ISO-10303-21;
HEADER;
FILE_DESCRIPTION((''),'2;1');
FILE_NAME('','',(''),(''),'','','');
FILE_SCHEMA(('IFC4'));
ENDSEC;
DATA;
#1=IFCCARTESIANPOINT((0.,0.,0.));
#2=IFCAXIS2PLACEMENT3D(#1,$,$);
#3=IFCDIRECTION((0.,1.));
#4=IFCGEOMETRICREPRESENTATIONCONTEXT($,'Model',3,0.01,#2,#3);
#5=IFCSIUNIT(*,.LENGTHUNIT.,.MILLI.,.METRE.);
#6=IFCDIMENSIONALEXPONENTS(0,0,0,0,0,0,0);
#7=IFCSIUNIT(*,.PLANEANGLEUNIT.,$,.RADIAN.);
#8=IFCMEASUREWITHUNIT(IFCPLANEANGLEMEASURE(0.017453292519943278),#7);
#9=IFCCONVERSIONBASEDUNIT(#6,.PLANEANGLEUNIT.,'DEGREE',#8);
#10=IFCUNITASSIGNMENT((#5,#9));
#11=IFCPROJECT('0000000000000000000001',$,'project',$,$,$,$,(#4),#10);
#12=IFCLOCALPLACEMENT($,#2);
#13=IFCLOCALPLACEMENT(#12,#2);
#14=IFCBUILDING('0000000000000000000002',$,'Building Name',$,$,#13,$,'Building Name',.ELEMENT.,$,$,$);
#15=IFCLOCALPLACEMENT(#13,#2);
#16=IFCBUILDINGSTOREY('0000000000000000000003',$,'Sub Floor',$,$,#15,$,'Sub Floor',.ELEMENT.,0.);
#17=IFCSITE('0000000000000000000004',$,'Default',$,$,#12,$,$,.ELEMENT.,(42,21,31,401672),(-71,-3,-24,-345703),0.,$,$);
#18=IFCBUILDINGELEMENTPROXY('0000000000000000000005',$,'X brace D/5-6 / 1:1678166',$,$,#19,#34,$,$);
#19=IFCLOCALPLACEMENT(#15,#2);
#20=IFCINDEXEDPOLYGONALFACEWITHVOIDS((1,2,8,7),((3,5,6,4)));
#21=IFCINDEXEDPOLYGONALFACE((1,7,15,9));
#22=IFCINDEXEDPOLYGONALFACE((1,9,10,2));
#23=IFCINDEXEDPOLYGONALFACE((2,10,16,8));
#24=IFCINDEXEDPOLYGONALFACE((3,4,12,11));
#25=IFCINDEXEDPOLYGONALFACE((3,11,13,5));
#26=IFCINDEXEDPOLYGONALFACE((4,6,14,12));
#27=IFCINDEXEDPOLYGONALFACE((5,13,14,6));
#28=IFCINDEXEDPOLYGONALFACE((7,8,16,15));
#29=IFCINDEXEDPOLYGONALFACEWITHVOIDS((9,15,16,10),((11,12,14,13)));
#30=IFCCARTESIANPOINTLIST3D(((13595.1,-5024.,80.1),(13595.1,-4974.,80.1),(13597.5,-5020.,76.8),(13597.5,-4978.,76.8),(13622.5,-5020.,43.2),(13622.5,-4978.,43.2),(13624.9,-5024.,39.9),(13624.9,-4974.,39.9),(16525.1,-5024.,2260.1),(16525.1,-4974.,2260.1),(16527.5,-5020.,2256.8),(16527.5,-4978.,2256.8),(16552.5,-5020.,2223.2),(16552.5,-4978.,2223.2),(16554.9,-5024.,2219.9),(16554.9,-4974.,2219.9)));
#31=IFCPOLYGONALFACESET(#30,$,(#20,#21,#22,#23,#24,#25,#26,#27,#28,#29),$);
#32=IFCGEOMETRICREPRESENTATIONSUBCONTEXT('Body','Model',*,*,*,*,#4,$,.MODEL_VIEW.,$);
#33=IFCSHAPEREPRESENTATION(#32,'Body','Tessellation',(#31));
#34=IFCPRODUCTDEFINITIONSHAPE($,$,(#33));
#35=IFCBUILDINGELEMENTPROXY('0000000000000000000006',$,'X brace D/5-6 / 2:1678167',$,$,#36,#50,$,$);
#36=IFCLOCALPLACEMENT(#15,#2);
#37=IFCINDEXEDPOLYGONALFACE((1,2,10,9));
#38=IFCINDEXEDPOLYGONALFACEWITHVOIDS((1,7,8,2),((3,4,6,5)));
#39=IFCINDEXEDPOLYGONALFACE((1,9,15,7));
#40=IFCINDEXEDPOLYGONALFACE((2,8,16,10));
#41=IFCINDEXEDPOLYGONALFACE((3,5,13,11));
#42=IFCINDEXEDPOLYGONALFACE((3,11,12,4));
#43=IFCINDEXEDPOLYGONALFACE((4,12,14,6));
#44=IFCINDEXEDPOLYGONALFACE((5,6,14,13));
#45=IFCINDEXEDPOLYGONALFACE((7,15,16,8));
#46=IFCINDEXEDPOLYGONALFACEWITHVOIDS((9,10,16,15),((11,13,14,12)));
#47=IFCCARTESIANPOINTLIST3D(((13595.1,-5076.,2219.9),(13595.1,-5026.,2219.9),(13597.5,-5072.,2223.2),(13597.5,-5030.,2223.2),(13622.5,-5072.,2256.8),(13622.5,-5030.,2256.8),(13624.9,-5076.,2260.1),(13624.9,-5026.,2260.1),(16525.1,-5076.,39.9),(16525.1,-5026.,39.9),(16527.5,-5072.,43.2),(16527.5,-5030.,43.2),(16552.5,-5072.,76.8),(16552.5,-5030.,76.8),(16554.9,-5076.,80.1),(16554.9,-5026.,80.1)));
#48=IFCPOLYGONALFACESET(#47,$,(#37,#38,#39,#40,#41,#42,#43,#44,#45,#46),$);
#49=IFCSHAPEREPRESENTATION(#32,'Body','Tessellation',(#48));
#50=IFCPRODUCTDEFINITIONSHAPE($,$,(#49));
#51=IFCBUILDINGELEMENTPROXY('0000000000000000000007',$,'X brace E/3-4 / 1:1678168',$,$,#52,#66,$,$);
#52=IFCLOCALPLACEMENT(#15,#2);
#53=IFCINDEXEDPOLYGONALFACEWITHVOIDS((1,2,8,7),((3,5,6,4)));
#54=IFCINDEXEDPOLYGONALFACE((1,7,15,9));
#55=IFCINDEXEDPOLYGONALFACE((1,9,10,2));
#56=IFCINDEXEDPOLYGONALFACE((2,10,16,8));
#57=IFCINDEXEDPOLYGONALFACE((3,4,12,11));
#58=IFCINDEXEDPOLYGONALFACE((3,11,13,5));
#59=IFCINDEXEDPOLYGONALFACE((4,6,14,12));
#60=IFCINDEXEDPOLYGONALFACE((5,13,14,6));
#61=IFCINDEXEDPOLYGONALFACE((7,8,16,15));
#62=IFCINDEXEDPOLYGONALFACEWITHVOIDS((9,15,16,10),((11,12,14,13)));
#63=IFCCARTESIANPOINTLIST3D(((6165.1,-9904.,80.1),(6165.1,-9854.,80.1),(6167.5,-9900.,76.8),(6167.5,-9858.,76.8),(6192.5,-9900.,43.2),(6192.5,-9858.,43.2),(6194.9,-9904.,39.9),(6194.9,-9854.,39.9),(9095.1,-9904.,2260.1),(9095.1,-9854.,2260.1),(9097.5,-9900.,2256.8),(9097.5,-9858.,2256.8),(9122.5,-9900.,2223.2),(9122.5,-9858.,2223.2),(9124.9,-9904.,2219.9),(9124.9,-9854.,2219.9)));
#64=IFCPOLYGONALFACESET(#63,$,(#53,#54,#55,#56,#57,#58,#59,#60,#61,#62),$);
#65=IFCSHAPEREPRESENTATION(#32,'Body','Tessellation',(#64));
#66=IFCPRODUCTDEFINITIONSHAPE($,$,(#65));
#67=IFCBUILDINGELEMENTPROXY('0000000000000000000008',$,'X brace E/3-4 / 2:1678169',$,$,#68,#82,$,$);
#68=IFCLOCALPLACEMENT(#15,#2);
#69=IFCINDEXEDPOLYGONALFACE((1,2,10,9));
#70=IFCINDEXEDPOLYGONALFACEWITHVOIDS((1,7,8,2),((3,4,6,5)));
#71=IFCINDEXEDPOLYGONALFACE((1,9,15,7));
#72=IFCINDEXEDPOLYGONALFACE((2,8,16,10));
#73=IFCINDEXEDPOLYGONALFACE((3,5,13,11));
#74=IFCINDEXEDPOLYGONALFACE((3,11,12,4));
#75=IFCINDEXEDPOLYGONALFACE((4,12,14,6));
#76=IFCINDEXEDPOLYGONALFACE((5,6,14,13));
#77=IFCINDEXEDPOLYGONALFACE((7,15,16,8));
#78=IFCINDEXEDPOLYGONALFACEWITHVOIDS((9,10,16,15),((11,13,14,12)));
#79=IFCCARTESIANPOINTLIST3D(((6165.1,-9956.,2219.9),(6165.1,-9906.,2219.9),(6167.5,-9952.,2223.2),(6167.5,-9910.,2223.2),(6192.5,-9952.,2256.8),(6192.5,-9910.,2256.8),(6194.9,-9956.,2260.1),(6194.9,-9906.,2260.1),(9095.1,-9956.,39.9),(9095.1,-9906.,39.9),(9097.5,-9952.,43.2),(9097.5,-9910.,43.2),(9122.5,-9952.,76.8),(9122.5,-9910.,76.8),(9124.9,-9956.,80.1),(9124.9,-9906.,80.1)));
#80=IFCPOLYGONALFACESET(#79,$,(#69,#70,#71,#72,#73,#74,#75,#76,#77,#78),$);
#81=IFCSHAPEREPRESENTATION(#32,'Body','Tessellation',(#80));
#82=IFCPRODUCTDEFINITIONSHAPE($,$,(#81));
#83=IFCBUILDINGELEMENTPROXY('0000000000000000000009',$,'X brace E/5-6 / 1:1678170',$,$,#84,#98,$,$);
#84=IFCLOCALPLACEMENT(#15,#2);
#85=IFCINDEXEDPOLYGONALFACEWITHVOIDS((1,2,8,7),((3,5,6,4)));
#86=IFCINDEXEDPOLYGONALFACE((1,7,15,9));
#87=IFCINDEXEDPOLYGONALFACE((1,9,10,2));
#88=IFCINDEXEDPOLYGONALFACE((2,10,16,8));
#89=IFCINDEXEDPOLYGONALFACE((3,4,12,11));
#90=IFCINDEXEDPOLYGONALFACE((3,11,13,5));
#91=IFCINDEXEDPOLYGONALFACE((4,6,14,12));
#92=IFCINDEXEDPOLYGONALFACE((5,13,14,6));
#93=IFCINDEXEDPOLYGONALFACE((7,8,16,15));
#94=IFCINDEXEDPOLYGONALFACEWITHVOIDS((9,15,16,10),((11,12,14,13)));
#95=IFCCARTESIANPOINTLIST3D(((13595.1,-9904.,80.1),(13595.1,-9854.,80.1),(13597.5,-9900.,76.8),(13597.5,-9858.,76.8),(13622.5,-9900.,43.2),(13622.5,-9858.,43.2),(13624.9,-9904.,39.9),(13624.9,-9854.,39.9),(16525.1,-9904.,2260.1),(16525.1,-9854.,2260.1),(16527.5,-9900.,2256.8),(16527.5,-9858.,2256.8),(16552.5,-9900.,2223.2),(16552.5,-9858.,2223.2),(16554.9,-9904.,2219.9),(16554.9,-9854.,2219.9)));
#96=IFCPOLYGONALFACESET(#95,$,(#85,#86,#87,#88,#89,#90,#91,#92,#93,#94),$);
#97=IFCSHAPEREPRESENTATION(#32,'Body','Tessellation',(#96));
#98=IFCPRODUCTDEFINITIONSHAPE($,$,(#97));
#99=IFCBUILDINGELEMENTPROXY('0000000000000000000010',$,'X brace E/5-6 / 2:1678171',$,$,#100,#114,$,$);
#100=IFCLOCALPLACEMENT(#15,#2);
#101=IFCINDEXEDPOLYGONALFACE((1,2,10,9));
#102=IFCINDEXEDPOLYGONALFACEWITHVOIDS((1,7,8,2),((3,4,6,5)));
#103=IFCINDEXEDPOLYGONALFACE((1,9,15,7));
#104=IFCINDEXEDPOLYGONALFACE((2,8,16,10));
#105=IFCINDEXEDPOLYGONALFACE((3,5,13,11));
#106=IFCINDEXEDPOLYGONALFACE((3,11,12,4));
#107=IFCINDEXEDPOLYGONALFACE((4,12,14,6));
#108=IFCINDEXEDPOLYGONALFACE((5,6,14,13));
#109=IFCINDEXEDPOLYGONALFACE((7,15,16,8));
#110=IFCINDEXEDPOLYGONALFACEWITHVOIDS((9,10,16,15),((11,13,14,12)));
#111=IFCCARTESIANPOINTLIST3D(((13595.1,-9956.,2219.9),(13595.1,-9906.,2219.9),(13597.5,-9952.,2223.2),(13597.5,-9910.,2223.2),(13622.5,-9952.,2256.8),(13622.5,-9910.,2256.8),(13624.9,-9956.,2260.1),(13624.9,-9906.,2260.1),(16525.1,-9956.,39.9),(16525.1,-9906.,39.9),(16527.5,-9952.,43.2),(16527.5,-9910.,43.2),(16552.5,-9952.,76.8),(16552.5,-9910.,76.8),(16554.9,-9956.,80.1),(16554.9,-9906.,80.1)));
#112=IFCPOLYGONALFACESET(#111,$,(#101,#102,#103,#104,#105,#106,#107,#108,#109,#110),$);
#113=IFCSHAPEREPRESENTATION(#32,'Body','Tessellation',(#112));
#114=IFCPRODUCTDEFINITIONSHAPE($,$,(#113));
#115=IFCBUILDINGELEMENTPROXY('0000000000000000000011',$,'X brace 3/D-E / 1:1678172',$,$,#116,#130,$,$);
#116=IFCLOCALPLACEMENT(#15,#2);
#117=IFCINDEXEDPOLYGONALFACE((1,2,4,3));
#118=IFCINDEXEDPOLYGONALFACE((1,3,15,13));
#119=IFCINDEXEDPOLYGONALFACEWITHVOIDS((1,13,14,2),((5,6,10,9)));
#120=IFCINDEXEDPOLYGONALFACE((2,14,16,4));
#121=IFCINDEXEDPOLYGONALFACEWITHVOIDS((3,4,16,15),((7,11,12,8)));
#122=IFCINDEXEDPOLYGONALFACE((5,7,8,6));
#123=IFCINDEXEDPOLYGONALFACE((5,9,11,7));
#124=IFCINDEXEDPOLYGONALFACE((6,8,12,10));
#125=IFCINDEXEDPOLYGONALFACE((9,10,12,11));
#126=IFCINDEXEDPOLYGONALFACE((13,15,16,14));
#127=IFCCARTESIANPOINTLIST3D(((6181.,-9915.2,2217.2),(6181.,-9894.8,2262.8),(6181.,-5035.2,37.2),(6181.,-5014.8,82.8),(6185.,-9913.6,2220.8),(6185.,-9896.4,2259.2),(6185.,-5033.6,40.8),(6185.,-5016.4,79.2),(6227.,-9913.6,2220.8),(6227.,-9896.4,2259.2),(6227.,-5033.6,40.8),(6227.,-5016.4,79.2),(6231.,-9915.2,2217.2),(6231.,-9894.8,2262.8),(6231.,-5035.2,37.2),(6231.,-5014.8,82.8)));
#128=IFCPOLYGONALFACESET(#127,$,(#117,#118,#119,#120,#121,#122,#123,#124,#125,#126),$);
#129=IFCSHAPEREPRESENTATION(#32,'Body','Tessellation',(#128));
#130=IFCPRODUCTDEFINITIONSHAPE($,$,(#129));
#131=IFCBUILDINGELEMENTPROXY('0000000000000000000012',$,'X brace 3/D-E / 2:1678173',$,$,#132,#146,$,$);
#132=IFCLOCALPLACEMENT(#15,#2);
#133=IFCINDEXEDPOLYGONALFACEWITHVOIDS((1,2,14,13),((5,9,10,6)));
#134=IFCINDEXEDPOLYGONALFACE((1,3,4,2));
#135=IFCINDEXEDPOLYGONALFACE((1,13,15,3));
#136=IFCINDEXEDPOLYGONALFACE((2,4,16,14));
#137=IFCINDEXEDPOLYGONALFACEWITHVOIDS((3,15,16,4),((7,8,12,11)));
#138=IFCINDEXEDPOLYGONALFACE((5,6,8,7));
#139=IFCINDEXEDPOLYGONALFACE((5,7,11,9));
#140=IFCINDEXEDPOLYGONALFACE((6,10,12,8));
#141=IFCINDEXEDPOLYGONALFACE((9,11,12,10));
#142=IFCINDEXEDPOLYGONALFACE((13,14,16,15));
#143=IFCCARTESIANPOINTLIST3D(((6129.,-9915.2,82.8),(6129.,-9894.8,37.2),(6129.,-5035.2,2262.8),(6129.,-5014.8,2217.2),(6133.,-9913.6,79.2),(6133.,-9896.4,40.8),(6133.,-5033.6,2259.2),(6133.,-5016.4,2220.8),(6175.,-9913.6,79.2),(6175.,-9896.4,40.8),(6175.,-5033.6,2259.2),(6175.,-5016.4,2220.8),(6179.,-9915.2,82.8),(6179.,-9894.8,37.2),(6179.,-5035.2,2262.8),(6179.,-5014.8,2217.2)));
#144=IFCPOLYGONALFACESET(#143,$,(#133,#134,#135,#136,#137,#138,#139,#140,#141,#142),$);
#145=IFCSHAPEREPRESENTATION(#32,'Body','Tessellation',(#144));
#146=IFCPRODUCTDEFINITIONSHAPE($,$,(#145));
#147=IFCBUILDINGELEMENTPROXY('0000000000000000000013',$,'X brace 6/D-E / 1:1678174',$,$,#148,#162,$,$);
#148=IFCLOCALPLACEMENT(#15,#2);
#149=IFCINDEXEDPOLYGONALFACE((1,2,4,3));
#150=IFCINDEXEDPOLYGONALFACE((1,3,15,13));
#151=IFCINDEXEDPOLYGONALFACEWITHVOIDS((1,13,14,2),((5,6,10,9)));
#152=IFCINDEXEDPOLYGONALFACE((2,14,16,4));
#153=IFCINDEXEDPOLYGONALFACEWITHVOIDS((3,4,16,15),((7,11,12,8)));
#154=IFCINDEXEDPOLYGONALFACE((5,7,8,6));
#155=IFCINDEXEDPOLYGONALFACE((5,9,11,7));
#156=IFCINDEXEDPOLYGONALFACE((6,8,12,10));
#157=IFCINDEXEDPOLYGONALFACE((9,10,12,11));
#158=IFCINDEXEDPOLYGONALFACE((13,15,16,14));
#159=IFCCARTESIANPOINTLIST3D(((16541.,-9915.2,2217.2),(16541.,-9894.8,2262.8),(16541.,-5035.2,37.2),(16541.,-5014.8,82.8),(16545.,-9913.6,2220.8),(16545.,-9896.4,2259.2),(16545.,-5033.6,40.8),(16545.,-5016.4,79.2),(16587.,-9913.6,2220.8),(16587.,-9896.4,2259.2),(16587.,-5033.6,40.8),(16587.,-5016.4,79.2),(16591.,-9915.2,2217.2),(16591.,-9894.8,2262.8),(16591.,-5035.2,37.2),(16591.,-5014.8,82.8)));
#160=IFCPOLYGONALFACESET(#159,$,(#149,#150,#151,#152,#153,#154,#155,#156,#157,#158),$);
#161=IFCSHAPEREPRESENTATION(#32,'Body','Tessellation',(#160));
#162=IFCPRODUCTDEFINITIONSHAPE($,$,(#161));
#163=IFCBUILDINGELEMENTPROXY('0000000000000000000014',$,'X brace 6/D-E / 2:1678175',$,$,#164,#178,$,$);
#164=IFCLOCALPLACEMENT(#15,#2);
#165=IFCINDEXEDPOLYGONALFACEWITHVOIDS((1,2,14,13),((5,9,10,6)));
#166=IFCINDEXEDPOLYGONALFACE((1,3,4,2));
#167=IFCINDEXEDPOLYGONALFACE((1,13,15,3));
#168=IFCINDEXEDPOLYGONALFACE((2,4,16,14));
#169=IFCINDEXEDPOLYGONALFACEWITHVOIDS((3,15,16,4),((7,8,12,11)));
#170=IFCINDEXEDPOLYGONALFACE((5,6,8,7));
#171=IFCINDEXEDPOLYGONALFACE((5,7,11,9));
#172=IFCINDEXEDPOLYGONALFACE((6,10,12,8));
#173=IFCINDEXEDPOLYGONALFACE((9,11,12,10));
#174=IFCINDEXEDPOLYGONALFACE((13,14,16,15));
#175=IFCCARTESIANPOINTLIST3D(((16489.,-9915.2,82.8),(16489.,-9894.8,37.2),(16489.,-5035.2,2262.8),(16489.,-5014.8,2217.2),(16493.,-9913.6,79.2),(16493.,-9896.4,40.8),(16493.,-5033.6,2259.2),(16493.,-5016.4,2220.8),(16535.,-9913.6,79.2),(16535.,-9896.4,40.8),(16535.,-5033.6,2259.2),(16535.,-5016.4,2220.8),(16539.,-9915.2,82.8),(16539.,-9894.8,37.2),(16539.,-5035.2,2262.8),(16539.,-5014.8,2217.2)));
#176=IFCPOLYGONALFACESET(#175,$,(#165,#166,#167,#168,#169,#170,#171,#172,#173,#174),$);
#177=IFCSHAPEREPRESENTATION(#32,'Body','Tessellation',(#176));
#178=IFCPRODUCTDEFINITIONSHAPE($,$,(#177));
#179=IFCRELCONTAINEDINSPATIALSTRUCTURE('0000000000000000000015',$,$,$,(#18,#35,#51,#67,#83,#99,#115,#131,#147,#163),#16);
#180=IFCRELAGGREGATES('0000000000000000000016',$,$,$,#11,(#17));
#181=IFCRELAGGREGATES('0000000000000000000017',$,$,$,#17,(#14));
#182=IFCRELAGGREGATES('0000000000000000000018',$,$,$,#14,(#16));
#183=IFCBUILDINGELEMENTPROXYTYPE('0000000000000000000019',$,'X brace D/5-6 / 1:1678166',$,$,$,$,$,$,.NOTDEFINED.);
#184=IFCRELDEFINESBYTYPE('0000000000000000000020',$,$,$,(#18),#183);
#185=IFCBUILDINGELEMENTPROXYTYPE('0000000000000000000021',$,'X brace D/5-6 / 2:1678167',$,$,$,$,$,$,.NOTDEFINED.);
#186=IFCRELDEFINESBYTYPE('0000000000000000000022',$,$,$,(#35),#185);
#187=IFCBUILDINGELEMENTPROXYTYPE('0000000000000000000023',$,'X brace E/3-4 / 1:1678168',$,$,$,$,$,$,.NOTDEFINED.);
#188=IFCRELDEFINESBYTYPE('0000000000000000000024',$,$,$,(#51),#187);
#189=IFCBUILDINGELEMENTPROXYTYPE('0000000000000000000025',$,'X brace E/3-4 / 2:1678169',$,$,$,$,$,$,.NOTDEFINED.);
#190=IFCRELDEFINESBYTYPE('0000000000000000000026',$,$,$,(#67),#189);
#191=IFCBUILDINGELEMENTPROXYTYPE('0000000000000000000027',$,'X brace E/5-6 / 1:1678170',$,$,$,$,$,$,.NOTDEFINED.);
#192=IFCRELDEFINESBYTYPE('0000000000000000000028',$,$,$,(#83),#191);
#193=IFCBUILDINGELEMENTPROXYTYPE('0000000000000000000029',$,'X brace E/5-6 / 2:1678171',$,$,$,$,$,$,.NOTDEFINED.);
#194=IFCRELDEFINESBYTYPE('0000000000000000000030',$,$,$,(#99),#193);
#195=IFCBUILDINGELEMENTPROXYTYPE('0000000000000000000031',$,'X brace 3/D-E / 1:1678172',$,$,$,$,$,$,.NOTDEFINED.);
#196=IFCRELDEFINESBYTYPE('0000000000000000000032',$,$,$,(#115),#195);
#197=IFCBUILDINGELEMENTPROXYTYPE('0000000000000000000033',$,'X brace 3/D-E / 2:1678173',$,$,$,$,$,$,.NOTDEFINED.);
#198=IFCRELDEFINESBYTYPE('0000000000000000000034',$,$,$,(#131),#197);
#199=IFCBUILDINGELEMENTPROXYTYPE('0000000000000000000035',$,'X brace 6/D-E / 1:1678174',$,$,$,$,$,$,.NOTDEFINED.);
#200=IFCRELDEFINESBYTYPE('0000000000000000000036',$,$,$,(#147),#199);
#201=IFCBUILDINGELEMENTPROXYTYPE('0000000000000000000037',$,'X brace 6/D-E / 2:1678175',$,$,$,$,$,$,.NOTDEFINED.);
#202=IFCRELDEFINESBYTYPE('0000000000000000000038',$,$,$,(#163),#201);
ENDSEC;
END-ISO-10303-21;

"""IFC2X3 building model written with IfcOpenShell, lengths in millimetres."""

from ifc_helpers import new_model, entity, si_unit, converted_unit, direction, frame, origin, place, context, subcontext, project, spatial, polyline, outline, extrude, type_object, element, save


model = new_model("IFC2X3")

# Units and contexts
model_context = context("Model", 3, precision=0.01, world=origin(), true_north=direction((0.0, 1.0)))
body_context = subcontext(model_context, "Body", "Model", "MODEL_VIEW")
ifc_project = project(units=[si_unit("LENGTHUNIT", "METRE", prefix="MILLI"), converted_unit("PLANEANGLEUNIT", "DEGREE", entity("IfcPlaneAngleMeasure", 0.017453292519943278), si_unit("PLANEANGLEUNIT", "RADIAN"), dimensions=[0, 0, 0, 0, 0, 0, 0])], contexts=[model_context])

# Site, building, storey
site_placement = place(None, origin())
site = spatial("IfcSite", under=ifc_project, at=site_placement, Name="Default", CompositionType="ELEMENT", RefLatitude=(42, 21, 31, 401672), RefLongitude=(-71, -3, -24, -345703), RefElevation=0.0)
building_placement = place(site_placement, origin())
building = spatial("IfcBuilding", under=site, at=building_placement, Name="Building Name", LongName="Building Name", CompositionType="ELEMENT")
storey_placement = place(building_placement, origin())
storey = spatial("IfcBuildingStorey", under=building, at=storey_placement, Name="Sub Floor", LongName="Sub Floor", CompositionType="ELEMENT", Elevation=0.0)

# Building element proxies
building_element_proxy_type_1 = type_object("IfcBuildingElementProxyType", Name="X brace D/5-6 / 1:1678166", PredefinedType="NOTDEFINED")
proxy_1_placement = place(storey_placement, origin())
element("IfcBuildingElementProxy", 1, at=proxy_1_placement, inside=storey, type_object=building_element_proxy_type_1, Name="X brace D/5-6 / 1:1678166", context=body_context, shape_type="SweptSolid", body=[
    extrude(outline(polyline([(-25.0, -25.0), (25.0, -25.0), (25.0, 25.0), (-25.0, 25.0), (-25.0, -25.0)]), holes=[polyline([(-21.0, -21.0), (-21.0, 21.0), (21.0, 21.0), (21.0, -21.0), (-21.0, -21.0)])]), frame((13610.0, -4999.0, 60.0), z_axis=(0.802294, 0.0, 0.596929), x_axis=(0.0, -1.0, 0.0)), (0.0, 0.0, 1.0), 3652.0),
])
building_element_proxy_type_2 = type_object("IfcBuildingElementProxyType", Name="X brace D/5-6 / 2:1678167", PredefinedType="NOTDEFINED")
proxy_2_placement = place(storey_placement, origin())
element("IfcBuildingElementProxy", 2, at=proxy_2_placement, inside=storey, type_object=building_element_proxy_type_2, Name="X brace D/5-6 / 2:1678167", context=body_context, shape_type="SweptSolid", body=[
    extrude(outline(polyline([(-25.0, -25.0), (25.0, -25.0), (25.0, 25.0), (-25.0, 25.0), (-25.0, -25.0)]), holes=[polyline([(-21.0, -21.0), (-21.0, 21.0), (21.0, 21.0), (21.0, -21.0), (-21.0, -21.0)])]), frame((13610.0, -5051.0, 2240.0), z_axis=(0.802294, 0.0, -0.596929), x_axis=(-0.596929, 0.0, -0.802294)), (0.0, 0.0, 1.0), 3652.0),
])
building_element_proxy_type_3 = type_object("IfcBuildingElementProxyType", Name="X brace E/3-4 / 1:1678168", PredefinedType="NOTDEFINED")
proxy_3_placement = place(storey_placement, origin())
element("IfcBuildingElementProxy", 3, at=proxy_3_placement, inside=storey, type_object=building_element_proxy_type_3, Name="X brace E/3-4 / 1:1678168", context=body_context, shape_type="SweptSolid", body=[
    extrude(outline(polyline([(-25.0, -25.0), (25.0, -25.0), (25.0, 25.0), (-25.0, 25.0), (-25.0, -25.0)]), holes=[polyline([(-21.0, -21.0), (-21.0, 21.0), (21.0, 21.0), (21.0, -21.0), (-21.0, -21.0)])]), frame((6180.0, -9879.0, 60.0), z_axis=(0.802294, 0.0, 0.596929), x_axis=(0.0, -1.0, 0.0)), (0.0, 0.0, 1.0), 3652.0),
])
building_element_proxy_type_4 = type_object("IfcBuildingElementProxyType", Name="X brace E/3-4 / 2:1678169", PredefinedType="NOTDEFINED")
proxy_4_placement = place(storey_placement, origin())
element("IfcBuildingElementProxy", 4, at=proxy_4_placement, inside=storey, type_object=building_element_proxy_type_4, Name="X brace E/3-4 / 2:1678169", context=body_context, shape_type="SweptSolid", body=[
    extrude(outline(polyline([(-25.0, -25.0), (25.0, -25.0), (25.0, 25.0), (-25.0, 25.0), (-25.0, -25.0)]), holes=[polyline([(-21.0, -21.0), (-21.0, 21.0), (21.0, 21.0), (21.0, -21.0), (-21.0, -21.0)])]), frame((6180.0, -9931.0, 2240.0), z_axis=(0.802294, 0.0, -0.596929), x_axis=(-0.596929, 0.0, -0.802294)), (0.0, 0.0, 1.0), 3652.0),
])
building_element_proxy_type_5 = type_object("IfcBuildingElementProxyType", Name="X brace E/5-6 / 1:1678170", PredefinedType="NOTDEFINED")
proxy_5_placement = place(storey_placement, origin())
element("IfcBuildingElementProxy", 5, at=proxy_5_placement, inside=storey, type_object=building_element_proxy_type_5, Name="X brace E/5-6 / 1:1678170", context=body_context, shape_type="SweptSolid", body=[
    extrude(outline(polyline([(-25.0, -25.0), (25.0, -25.0), (25.0, 25.0), (-25.0, 25.0), (-25.0, -25.0)]), holes=[polyline([(-21.0, -21.0), (-21.0, 21.0), (21.0, 21.0), (21.0, -21.0), (-21.0, -21.0)])]), frame((13610.0, -9879.0, 60.0), z_axis=(0.802294, 0.0, 0.596929), x_axis=(0.0, -1.0, 0.0)), (0.0, 0.0, 1.0), 3652.0),
])
building_element_proxy_type_6 = type_object("IfcBuildingElementProxyType", Name="X brace E/5-6 / 2:1678171", PredefinedType="NOTDEFINED")
proxy_6_placement = place(storey_placement, origin())
element("IfcBuildingElementProxy", 6, at=proxy_6_placement, inside=storey, type_object=building_element_proxy_type_6, Name="X brace E/5-6 / 2:1678171", context=body_context, shape_type="SweptSolid", body=[
    extrude(outline(polyline([(-25.0, -25.0), (25.0, -25.0), (25.0, 25.0), (-25.0, 25.0), (-25.0, -25.0)]), holes=[polyline([(-21.0, -21.0), (-21.0, 21.0), (21.0, 21.0), (21.0, -21.0), (-21.0, -21.0)])]), frame((13610.0, -9931.0, 2240.0), z_axis=(0.802294, 0.0, -0.596929), x_axis=(-0.596929, 0.0, -0.802294)), (0.0, 0.0, 1.0), 3652.0),
])
building_element_proxy_type_7 = type_object("IfcBuildingElementProxyType", Name="X brace 3/D-E / 1:1678172", PredefinedType="NOTDEFINED")
proxy_7_placement = place(storey_placement, origin())
element("IfcBuildingElementProxy", 7, at=proxy_7_placement, inside=storey, type_object=building_element_proxy_type_7, Name="X brace 3/D-E / 1:1678172", context=body_context, shape_type="SweptSolid", body=[
    extrude(outline(polyline([(-25.0, -25.0), (25.0, -25.0), (25.0, 25.0), (-25.0, 25.0), (-25.0, -25.0)]), holes=[polyline([(-21.0, -21.0), (-21.0, 21.0), (21.0, 21.0), (21.0, -21.0), (-21.0, -21.0)])]), frame((6206.0, -9905.0, 2240.0), z_axis=(0.0, 0.913038, -0.407874), x_axis=(0.0, -0.407874, -0.913038)), (0.0, 0.0, 1.0), 5344.8),
])
building_element_proxy_type_8 = type_object("IfcBuildingElementProxyType", Name="X brace 3/D-E / 2:1678173", PredefinedType="NOTDEFINED")
proxy_8_placement = place(storey_placement, origin())
element("IfcBuildingElementProxy", 8, at=proxy_8_placement, inside=storey, type_object=building_element_proxy_type_8, Name="X brace 3/D-E / 2:1678173", context=body_context, shape_type="SweptSolid", body=[
    extrude(outline(polyline([(-25.0, -25.0), (25.0, -25.0), (25.0, 25.0), (-25.0, 25.0), (-25.0, -25.0)]), holes=[polyline([(-21.0, -21.0), (-21.0, 21.0), (21.0, 21.0), (21.0, -21.0), (-21.0, -21.0)])]), frame((6154.0, -9905.0, 60.0), z_axis=(0.0, 0.913038, 0.407874), x_axis=(1.0, 0.0, 0.0)), (0.0, 0.0, 1.0), 5344.8),
])
building_element_proxy_type_9 = type_object("IfcBuildingElementProxyType", Name="X brace 6/D-E / 1:1678174", PredefinedType="NOTDEFINED")
proxy_9_placement = place(storey_placement, origin())
element("IfcBuildingElementProxy", 9, at=proxy_9_placement, inside=storey, type_object=building_element_proxy_type_9, Name="X brace 6/D-E / 1:1678174", context=body_context, shape_type="SweptSolid", body=[
    extrude(outline(polyline([(-25.0, -25.0), (25.0, -25.0), (25.0, 25.0), (-25.0, 25.0), (-25.0, -25.0)]), holes=[polyline([(-21.0, -21.0), (-21.0, 21.0), (21.0, 21.0), (21.0, -21.0), (-21.0, -21.0)])]), frame((16566.0, -9905.0, 2240.0), z_axis=(0.0, 0.913038, -0.407874), x_axis=(0.0, -0.407874, -0.913038)), (0.0, 0.0, 1.0), 5344.8),
])
building_element_proxy_type_10 = type_object("IfcBuildingElementProxyType", Name="X brace 6/D-E / 2:1678175", PredefinedType="NOTDEFINED")
proxy_10_placement = place(storey_placement, origin())
element("IfcBuildingElementProxy", 10, at=proxy_10_placement, inside=storey, type_object=building_element_proxy_type_10, Name="X brace 6/D-E / 2:1678175", context=body_context, shape_type="SweptSolid", body=[
    extrude(outline(polyline([(-25.0, -25.0), (25.0, -25.0), (25.0, 25.0), (-25.0, 25.0), (-25.0, -25.0)]), holes=[polyline([(-21.0, -21.0), (-21.0, 21.0), (21.0, 21.0), (21.0, -21.0), (-21.0, -21.0)])]), frame((16514.0, -9905.0, 60.0), z_axis=(0.0, 0.913038, 0.407874), x_axis=(1.0, 0.0, 0.0)), (0.0, 0.0, 1.0), 5344.8),
])

save(model, "model.ifc")
